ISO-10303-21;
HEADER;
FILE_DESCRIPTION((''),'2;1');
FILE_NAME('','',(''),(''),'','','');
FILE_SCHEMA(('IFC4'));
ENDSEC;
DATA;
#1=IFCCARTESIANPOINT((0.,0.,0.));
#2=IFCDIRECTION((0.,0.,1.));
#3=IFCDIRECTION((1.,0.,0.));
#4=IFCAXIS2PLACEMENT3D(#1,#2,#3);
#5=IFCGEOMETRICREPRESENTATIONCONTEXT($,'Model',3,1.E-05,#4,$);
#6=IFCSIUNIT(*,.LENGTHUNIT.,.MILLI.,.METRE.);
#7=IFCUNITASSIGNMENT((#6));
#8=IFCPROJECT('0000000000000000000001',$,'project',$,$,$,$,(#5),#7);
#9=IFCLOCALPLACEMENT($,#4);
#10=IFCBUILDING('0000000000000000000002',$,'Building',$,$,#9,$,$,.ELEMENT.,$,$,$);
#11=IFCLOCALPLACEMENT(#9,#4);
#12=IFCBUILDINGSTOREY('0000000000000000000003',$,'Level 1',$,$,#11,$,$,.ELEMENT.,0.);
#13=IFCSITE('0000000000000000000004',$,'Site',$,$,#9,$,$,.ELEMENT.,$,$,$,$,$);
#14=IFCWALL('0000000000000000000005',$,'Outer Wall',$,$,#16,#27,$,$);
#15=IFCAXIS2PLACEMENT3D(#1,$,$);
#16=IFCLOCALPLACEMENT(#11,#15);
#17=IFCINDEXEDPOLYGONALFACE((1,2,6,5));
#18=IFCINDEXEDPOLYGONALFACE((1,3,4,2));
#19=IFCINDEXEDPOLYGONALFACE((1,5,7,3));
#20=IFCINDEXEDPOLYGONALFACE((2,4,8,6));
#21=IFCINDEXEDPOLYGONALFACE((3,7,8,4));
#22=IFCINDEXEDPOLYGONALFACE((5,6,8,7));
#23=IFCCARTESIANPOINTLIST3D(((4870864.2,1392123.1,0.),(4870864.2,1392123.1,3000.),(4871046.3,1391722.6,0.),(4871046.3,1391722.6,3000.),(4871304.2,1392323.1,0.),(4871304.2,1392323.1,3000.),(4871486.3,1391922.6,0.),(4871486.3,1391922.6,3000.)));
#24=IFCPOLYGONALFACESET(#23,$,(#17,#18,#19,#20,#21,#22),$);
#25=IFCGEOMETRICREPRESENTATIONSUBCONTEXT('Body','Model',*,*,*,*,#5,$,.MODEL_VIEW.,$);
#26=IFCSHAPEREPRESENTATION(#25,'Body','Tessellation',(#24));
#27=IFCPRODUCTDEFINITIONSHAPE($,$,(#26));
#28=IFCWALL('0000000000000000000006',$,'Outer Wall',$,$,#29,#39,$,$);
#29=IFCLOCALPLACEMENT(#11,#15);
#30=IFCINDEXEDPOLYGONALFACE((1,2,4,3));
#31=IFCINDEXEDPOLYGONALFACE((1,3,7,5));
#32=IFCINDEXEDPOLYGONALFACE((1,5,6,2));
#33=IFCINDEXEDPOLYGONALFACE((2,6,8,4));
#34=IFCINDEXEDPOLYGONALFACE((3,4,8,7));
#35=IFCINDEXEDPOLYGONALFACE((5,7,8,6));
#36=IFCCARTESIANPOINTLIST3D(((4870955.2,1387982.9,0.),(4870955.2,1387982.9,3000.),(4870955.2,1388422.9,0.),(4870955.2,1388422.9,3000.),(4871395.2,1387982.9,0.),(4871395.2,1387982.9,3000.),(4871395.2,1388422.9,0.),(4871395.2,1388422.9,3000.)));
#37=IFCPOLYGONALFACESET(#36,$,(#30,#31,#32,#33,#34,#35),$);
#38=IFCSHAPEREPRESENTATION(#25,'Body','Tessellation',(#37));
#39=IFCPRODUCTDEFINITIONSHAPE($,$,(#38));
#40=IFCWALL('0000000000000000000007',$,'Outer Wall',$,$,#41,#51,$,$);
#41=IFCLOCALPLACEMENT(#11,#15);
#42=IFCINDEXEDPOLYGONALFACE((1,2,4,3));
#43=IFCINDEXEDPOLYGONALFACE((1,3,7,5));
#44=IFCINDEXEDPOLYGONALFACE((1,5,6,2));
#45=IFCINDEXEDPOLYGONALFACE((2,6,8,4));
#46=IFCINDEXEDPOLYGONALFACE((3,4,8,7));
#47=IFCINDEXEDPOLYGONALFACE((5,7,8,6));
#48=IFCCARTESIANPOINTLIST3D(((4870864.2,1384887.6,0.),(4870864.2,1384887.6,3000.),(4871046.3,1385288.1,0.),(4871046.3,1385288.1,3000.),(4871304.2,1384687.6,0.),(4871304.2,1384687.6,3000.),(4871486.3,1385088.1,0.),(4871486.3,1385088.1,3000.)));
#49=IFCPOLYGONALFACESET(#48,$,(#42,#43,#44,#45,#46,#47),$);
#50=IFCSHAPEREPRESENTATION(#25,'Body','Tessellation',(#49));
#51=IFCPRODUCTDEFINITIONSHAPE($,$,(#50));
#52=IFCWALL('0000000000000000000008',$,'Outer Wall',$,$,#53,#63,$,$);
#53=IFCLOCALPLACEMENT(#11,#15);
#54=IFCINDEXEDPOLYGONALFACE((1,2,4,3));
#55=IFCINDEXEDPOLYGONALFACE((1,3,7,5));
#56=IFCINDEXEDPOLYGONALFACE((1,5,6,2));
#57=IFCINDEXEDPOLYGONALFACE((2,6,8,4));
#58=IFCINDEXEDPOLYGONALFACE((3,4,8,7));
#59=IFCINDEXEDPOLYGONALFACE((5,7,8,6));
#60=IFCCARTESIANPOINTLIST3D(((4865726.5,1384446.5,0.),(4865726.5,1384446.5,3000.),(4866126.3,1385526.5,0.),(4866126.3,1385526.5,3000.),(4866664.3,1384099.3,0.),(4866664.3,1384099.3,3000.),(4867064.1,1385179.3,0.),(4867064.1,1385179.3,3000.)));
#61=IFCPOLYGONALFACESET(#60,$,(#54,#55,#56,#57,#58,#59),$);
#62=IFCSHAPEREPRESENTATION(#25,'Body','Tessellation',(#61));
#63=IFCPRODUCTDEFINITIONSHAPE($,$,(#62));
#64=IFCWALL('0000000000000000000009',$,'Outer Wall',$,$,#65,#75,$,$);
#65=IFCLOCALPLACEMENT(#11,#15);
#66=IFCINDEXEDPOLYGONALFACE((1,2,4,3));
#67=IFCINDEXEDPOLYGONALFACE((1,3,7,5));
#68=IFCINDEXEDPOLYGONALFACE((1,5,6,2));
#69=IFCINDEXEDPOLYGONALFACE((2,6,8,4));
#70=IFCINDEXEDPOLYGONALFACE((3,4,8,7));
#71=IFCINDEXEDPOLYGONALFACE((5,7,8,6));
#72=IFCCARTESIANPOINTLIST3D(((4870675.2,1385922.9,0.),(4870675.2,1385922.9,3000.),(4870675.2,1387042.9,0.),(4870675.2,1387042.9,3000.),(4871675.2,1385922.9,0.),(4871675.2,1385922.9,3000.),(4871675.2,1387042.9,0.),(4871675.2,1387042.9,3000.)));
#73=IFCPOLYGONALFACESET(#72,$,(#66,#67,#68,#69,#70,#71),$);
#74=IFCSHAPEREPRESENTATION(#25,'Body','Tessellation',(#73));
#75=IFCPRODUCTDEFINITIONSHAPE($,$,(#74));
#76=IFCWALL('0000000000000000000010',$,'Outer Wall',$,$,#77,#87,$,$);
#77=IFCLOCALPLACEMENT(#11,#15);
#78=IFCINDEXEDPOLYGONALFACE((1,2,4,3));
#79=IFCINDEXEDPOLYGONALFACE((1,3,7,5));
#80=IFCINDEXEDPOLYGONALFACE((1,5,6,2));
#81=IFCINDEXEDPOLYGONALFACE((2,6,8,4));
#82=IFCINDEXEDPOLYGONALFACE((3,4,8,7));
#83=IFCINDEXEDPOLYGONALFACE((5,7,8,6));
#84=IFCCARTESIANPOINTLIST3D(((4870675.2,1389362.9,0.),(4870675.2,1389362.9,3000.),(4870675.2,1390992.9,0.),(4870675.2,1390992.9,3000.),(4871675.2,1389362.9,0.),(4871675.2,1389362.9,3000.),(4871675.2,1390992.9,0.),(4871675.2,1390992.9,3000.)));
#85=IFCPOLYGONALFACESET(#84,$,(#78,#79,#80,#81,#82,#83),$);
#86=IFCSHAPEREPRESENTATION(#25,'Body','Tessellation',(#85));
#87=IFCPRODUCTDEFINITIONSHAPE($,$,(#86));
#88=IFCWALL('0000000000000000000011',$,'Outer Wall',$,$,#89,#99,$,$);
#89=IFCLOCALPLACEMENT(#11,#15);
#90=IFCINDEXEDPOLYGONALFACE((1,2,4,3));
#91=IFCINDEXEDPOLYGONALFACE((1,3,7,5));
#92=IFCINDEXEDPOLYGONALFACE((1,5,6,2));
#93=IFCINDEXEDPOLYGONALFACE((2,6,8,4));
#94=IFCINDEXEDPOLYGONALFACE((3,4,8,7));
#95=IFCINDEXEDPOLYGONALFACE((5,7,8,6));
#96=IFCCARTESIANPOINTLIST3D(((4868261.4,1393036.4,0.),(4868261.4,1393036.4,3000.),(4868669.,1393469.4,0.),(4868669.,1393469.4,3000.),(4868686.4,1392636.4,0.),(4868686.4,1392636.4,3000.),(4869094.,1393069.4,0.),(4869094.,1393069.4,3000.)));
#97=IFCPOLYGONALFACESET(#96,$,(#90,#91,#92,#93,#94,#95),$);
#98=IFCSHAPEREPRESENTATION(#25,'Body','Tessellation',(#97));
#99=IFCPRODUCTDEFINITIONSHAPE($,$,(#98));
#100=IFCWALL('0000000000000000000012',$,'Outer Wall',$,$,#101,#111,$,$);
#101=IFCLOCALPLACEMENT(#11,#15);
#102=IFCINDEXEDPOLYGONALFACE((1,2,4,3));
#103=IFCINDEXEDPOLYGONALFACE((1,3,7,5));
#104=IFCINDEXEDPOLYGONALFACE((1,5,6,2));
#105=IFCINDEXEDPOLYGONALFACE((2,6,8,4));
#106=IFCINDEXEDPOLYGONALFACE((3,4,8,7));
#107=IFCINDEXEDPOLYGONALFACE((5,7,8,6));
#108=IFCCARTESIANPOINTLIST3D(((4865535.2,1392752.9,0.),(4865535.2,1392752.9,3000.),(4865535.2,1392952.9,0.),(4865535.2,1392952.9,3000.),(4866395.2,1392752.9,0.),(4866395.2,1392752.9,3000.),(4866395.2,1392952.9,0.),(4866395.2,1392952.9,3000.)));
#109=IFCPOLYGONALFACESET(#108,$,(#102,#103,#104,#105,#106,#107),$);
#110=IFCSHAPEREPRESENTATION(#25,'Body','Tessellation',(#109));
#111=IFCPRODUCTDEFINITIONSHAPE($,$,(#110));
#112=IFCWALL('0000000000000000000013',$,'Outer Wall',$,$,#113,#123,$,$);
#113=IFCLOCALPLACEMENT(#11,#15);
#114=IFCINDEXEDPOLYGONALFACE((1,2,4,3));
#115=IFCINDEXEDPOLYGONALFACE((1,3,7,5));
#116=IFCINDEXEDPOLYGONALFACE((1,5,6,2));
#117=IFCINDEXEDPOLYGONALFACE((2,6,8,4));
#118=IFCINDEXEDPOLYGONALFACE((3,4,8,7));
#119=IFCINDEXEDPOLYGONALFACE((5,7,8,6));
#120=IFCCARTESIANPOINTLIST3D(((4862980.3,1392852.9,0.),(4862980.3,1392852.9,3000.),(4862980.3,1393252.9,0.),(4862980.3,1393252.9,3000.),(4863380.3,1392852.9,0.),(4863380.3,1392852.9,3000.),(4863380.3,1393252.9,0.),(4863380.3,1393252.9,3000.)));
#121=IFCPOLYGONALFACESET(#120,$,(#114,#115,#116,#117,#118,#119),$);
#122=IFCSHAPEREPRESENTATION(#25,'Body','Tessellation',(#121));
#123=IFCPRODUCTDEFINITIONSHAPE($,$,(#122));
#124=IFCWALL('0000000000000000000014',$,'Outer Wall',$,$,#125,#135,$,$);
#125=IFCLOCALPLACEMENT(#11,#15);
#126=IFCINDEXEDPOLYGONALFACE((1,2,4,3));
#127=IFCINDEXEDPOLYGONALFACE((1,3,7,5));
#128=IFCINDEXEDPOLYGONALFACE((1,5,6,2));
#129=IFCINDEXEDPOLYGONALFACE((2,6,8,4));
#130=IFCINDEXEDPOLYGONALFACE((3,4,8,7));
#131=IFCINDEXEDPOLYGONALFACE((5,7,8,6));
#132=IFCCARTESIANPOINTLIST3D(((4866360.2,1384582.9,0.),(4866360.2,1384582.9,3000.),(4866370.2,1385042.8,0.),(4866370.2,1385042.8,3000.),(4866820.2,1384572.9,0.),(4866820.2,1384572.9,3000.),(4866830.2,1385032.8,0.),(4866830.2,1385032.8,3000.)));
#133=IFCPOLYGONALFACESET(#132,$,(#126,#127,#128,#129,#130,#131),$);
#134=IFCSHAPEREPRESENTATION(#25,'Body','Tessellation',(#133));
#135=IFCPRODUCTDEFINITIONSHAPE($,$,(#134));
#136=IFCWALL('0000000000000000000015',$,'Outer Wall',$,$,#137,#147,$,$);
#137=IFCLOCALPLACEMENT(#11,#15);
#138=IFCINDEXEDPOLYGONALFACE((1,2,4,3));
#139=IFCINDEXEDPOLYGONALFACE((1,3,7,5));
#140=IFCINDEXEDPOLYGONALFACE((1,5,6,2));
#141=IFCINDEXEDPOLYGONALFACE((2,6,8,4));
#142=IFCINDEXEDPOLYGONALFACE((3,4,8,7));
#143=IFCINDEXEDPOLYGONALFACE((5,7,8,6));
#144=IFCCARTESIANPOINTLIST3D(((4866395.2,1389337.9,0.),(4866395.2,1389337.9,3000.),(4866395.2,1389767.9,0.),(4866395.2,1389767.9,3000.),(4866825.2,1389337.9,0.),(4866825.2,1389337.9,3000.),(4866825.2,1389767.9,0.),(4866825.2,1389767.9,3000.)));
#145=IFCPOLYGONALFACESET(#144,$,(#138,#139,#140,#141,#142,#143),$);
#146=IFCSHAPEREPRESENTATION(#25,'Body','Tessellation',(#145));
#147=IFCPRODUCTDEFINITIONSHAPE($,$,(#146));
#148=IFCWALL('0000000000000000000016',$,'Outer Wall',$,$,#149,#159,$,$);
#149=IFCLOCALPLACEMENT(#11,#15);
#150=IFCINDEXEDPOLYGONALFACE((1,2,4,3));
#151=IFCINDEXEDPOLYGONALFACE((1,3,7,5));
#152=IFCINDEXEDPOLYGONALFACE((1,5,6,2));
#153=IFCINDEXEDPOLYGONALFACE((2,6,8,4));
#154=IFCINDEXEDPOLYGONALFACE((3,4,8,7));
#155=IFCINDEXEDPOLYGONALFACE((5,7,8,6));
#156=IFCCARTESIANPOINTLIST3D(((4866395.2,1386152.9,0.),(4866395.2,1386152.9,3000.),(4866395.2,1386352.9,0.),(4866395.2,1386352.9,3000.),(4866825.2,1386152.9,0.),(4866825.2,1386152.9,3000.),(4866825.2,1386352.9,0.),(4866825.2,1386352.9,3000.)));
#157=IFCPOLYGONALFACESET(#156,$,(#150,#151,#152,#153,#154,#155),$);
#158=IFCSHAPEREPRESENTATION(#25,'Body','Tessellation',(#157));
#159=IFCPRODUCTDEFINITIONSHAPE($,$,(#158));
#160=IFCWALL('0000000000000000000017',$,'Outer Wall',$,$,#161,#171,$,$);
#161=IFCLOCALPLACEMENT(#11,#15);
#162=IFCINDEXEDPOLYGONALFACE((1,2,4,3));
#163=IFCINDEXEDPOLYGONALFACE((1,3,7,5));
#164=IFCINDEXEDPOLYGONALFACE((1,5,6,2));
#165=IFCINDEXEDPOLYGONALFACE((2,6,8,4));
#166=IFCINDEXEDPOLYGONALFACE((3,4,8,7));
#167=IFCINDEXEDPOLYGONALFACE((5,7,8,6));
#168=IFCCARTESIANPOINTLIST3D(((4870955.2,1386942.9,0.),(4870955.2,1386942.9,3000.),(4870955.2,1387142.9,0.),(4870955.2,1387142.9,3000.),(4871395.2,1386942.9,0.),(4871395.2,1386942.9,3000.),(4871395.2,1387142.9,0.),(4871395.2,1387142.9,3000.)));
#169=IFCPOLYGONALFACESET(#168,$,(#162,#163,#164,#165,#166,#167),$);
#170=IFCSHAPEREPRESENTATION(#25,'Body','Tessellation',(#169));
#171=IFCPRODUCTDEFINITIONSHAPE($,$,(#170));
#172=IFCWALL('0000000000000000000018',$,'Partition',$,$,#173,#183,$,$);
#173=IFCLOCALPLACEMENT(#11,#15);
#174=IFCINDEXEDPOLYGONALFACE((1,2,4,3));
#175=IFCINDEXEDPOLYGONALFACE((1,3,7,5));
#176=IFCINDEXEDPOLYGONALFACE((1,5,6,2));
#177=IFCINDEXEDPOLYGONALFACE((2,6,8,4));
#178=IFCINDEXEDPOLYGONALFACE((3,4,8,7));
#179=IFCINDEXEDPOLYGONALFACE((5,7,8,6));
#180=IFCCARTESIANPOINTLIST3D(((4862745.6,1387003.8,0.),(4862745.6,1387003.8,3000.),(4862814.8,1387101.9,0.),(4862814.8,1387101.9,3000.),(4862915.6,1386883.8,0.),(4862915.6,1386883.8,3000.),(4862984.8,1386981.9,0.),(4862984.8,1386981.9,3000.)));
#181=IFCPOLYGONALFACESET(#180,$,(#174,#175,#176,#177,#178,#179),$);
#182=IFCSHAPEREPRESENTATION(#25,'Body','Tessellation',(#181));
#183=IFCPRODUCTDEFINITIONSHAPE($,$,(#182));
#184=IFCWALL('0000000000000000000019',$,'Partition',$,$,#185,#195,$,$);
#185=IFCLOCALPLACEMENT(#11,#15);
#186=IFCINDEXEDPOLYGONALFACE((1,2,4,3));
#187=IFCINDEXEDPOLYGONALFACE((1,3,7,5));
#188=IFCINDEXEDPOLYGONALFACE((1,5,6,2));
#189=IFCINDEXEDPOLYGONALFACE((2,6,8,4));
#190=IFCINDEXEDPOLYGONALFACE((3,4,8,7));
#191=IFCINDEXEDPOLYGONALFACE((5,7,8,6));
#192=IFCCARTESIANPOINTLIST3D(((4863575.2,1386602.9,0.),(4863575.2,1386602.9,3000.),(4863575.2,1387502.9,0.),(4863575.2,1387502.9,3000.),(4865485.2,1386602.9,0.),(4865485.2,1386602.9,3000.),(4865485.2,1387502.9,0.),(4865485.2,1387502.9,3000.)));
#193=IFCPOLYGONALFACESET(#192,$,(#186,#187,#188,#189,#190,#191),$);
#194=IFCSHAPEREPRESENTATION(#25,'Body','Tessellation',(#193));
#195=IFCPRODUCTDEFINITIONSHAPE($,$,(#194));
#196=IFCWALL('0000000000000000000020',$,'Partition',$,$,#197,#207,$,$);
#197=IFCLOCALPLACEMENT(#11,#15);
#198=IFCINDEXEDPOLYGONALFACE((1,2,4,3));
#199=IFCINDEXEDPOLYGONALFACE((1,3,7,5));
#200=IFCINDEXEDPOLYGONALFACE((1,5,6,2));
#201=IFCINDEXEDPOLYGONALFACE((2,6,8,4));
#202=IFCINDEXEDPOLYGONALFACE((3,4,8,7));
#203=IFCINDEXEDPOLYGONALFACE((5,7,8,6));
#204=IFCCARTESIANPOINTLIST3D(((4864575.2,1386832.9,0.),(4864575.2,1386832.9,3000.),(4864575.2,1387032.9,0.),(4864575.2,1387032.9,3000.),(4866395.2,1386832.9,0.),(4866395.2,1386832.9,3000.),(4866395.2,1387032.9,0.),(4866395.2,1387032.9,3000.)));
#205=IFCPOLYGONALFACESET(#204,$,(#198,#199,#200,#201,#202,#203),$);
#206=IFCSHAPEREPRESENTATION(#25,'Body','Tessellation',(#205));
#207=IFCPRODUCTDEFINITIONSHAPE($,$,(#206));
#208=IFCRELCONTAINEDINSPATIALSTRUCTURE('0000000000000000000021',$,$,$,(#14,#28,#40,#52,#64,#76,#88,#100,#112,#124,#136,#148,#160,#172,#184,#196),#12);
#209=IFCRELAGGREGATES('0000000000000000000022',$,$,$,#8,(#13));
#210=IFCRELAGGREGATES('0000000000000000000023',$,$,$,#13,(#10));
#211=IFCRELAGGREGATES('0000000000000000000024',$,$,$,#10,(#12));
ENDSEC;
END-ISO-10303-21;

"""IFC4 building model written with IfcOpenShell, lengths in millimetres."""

from ifc_helpers import new_model, si_unit, frame, frame_2d, origin_with_axes, place, context, subcontext, project, spatial, rectangle, extrude, element, save


model = new_model("IFC4")

# Units and contexts
model_context = context("Model", 3, precision=1e-05, world=origin_with_axes())
body_context = subcontext(model_context, "Body", "Model", "MODEL_VIEW")
ifc_project = project(units=[si_unit("LENGTHUNIT", "METRE", prefix="MILLI")], contexts=[model_context])

# Site, building, storey
placement = place(None, origin_with_axes())
site = spatial("IfcSite", under=ifc_project, at=placement, Name="Site", CompositionType="ELEMENT")
building = spatial("IfcBuilding", under=site, at=placement, Name="Building", CompositionType="ELEMENT")
storey_placement = place(placement, origin_with_axes())
storey = spatial("IfcBuildingStorey", under=building, at=storey_placement, Name="Level 1", CompositionType="ELEMENT", Elevation=0.0)

# Walls
wall_1_placement = place(placement, frame((4871395.2, 1392122.9, 0.0), z_axis=(0.0, 0.0, 1.0), x_axis=(-0.910366, -0.413803, 0.0)))
element("IfcWall", 1, at=wall_1_placement, inside=storey, Name="Outer Wall", context=body_context, shape_type="SweptSolid", body=[
    extrude(rectangle(XDim=483.3, YDim=440.0, at=frame_2d((241.7, 0.0), x_axis=(1.0, 0.0))), origin_with_axes(), (0.0, 0.0, 1.0), 3000.0),
])
wall_2_placement = place(placement, frame((4871395.2, 1388202.9, 0.0), z_axis=(0.0, 0.0, 1.0), x_axis=(-1.0, 0.0, 0.0)))
element("IfcWall", 2, at=wall_2_placement, inside=storey, Name="Outer Wall", context=body_context, shape_type="SweptSolid", body=[
    extrude(rectangle(XDim=440.0, YDim=440.0, at=frame_2d((220.0, 0.0), x_axis=(1.0, 0.0))), origin_with_axes(), (0.0, 0.0, 1.0), 3000.0),
])
wall_3_placement = place(placement, frame((4871395.2, 1384887.9, 0.0), z_axis=(0.0, 0.0, 1.0), x_axis=(-0.910366, 0.413803, 0.0)))
element("IfcWall", 3, at=wall_3_placement, inside=storey, Name="Outer Wall", context=body_context, shape_type="SweptSolid", body=[
    extrude(rectangle(XDim=483.3, YDim=440.0, at=frame_2d((241.7, 0.0), x_axis=(1.0, 0.0))), origin_with_axes(), (0.0, 0.0, 1.0), 3000.0),
])
wall_4_placement = place(placement, frame((4866195.4, 1384272.9, 0.0), z_axis=(0.0, 0.0, 1.0), x_axis=(0.347176, 0.9378, 0.0)))
element("IfcWall", 4, at=wall_4_placement, inside=storey, Name="Outer Wall", context=body_context, shape_type="SweptSolid", body=[
    extrude(rectangle(XDim=1151.6, YDim=1000.0, at=frame_2d((575.8, 0.0), x_axis=(1.0, 0.0))), origin_with_axes(), (0.0, 0.0, 1.0), 3000.0),
])
wall_5_placement = place(placement, frame((4871175.2, 1385922.9, 0.0), z_axis=(0.0, 0.0, 1.0), x_axis=(0.0, 1.0, 0.0)))
element("IfcWall", 5, at=wall_5_placement, inside=storey, Name="Outer Wall", context=body_context, shape_type="SweptSolid", body=[
    extrude(rectangle(XDim=1120.0, YDim=1000.0, at=frame_2d((560.0, 0.0), x_axis=(1.0, 0.0))), origin_with_axes(), (0.0, 0.0, 1.0), 3000.0),
])
wall_6_placement = place(placement, frame((4871175.2, 1389362.9, 0.0), z_axis=(0.0, 0.0, 1.0), x_axis=(0.0, 1.0, 0.0)))
element("IfcWall", 6, at=wall_6_placement, inside=storey, Name="Outer Wall", context=body_context, shape_type="SweptSolid", body=[
    extrude(rectangle(XDim=1630.0, YDim=1000.0, at=frame_2d((815.0, 0.0), x_axis=(1.0, 0.0))), origin_with_axes(), (0.0, 0.0, 1.0), 3000.0),
])
wall_7_placement = place(placement, frame((4868890.2, 1392852.9, 0.0), z_axis=(0.0, 0.0, 1.0), x_axis=(-0.7282, 0.685365, 0.0)))
element("IfcWall", 7, at=wall_7_placement, inside=storey, Name="Outer Wall", context=body_context, shape_type="SweptSolid", body=[
    extrude(rectangle(XDim=583.6, YDim=594.6, at=frame_2d((291.8, 0.0), x_axis=(1.0, 0.0))), origin_with_axes(), (0.0, 0.0, 1.0), 3000.0),
])
wall_8_placement = place(placement, frame((4866395.2, 1392852.9, 0.0), z_axis=(0.0, 0.0, 1.0), x_axis=(-1.0, 0.0, 0.0)))
element("IfcWall", 8, at=wall_8_placement, inside=storey, Name="Outer Wall", context=body_context, shape_type="SweptSolid", body=[
    extrude(rectangle(XDim=860.0, YDim=200.0, at=frame_2d((430.0, 0.0), x_axis=(1.0, 0.0))), origin_with_axes(), (0.0, 0.0, 1.0), 3000.0),
])
wall_9_placement = place(placement, frame((4863180.3, 1392852.9, 0.0), z_axis=(0.0, 0.0, 1.0), x_axis=(0.0, 1.0, 0.0)))
element("IfcWall", 9, at=wall_9_placement, inside=storey, Name="Outer Wall", context=body_context, shape_type="SweptSolid", body=[
    extrude(rectangle(XDim=400.0, YDim=400.0, at=frame_2d((200.0, 0.0), x_axis=(1.0, 0.0))), origin_with_axes(), (0.0, 0.0, 1.0), 3000.0),
])
wall_10_placement = place(placement, frame((4866365.2, 1384812.9, 0.0), z_axis=(0.0, 0.0, 1.0), x_axis=(0.999764, -0.021734, 0.0)))
element("IfcWall", 10, at=wall_10_placement, inside=storey, Name="Outer Wall", context=body_context, shape_type="SweptSolid", body=[
    extrude(rectangle(XDim=460.1, YDim=460.0, at=frame_2d((230.1, 0.0), x_axis=(1.0, 0.0))), origin_with_axes(), (0.0, 0.0, 1.0), 3000.0),
])
wall_11_placement = place(placement, frame((4866395.2, 1389552.9, 0.0), z_axis=(0.0, 0.0, 1.0), x_axis=(1.0, 0.0, 0.0)))
element("IfcWall", 11, at=wall_11_placement, inside=storey, Name="Outer Wall", context=body_context, shape_type="SweptSolid", body=[
    extrude(rectangle(XDim=430.0, YDim=430.0, at=frame_2d((215.0, 0.0), x_axis=(1.0, 0.0))), origin_with_axes(), (0.0, 0.0, 1.0), 3000.0),
])
wall_12_placement = place(placement, frame((4866395.2, 1386252.9, 0.0), z_axis=(0.0, 0.0, 1.0), x_axis=(1.0, 0.0, 0.0)))
element("IfcWall", 12, at=wall_12_placement, inside=storey, Name="Outer Wall", context=body_context, shape_type="SweptSolid", body=[
    extrude(rectangle(XDim=430.0, YDim=200.0, at=frame_2d((215.0, 0.0), x_axis=(1.0, 0.0))), origin_with_axes(), (0.0, 0.0, 1.0), 3000.0),
])
wall_13_placement = place(placement, frame((4870955.2, 1387042.9, 0.0), z_axis=(0.0, 0.0, 1.0), x_axis=(1.0, 0.0, 0.0)))
element("IfcWall", 13, at=wall_13_placement, inside=storey, Name="Outer Wall", context=body_context, shape_type="SweptSolid", body=[
    extrude(rectangle(XDim=440.0, YDim=200.0, at=frame_2d((220.0, 0.0), x_axis=(1.0, 0.0))), origin_with_axes(), (0.0, 0.0, 1.0), 3000.0),
])
wall_14_placement = place(placement, frame((4862780.2, 1387052.9, 0.0), z_axis=(0.0, 0.0, 1.0), x_axis=(0.816968, -0.576683, 0.0)))
element("IfcWall", 14, at=wall_14_placement, inside=storey, Name="Partition", context=body_context, shape_type="SweptSolid", body=[
    extrude(rectangle(XDim=208.1, YDim=120.0, at=frame_2d((104.0, 0.0), x_axis=(1.0, 0.0))), origin_with_axes(), (0.0, 0.0, 1.0), 3000.0),
])
wall_15_placement = place(placement, frame((4863575.2, 1387052.9, 0.0), z_axis=(0.0, 0.0, 1.0), x_axis=(1.0, 0.0, 0.0)))
element("IfcWall", 15, at=wall_15_placement, inside=storey, Name="Partition", context=body_context, shape_type="SweptSolid", body=[
    extrude(rectangle(XDim=1910.0, YDim=900.0, at=frame_2d((955.0, 0.0), x_axis=(1.0, 0.0))), origin_with_axes(), (0.0, 0.0, 1.0), 3000.0),
])
wall_16_placement = place(placement, frame((4864575.2, 1386932.9, 0.0), z_axis=(0.0, 0.0, 1.0), x_axis=(1.0, 0.0, 0.0)))
element("IfcWall", 16, at=wall_16_placement, inside=storey, Name="Partition", context=body_context, shape_type="SweptSolid", body=[
    extrude(rectangle(XDim=1820.0, YDim=200.0, at=frame_2d((910.0, 0.0), x_axis=(1.0, 0.0))), origin_with_axes(), (0.0, 0.0, 1.0), 3000.0),
])

save(model, "model.ifc")
